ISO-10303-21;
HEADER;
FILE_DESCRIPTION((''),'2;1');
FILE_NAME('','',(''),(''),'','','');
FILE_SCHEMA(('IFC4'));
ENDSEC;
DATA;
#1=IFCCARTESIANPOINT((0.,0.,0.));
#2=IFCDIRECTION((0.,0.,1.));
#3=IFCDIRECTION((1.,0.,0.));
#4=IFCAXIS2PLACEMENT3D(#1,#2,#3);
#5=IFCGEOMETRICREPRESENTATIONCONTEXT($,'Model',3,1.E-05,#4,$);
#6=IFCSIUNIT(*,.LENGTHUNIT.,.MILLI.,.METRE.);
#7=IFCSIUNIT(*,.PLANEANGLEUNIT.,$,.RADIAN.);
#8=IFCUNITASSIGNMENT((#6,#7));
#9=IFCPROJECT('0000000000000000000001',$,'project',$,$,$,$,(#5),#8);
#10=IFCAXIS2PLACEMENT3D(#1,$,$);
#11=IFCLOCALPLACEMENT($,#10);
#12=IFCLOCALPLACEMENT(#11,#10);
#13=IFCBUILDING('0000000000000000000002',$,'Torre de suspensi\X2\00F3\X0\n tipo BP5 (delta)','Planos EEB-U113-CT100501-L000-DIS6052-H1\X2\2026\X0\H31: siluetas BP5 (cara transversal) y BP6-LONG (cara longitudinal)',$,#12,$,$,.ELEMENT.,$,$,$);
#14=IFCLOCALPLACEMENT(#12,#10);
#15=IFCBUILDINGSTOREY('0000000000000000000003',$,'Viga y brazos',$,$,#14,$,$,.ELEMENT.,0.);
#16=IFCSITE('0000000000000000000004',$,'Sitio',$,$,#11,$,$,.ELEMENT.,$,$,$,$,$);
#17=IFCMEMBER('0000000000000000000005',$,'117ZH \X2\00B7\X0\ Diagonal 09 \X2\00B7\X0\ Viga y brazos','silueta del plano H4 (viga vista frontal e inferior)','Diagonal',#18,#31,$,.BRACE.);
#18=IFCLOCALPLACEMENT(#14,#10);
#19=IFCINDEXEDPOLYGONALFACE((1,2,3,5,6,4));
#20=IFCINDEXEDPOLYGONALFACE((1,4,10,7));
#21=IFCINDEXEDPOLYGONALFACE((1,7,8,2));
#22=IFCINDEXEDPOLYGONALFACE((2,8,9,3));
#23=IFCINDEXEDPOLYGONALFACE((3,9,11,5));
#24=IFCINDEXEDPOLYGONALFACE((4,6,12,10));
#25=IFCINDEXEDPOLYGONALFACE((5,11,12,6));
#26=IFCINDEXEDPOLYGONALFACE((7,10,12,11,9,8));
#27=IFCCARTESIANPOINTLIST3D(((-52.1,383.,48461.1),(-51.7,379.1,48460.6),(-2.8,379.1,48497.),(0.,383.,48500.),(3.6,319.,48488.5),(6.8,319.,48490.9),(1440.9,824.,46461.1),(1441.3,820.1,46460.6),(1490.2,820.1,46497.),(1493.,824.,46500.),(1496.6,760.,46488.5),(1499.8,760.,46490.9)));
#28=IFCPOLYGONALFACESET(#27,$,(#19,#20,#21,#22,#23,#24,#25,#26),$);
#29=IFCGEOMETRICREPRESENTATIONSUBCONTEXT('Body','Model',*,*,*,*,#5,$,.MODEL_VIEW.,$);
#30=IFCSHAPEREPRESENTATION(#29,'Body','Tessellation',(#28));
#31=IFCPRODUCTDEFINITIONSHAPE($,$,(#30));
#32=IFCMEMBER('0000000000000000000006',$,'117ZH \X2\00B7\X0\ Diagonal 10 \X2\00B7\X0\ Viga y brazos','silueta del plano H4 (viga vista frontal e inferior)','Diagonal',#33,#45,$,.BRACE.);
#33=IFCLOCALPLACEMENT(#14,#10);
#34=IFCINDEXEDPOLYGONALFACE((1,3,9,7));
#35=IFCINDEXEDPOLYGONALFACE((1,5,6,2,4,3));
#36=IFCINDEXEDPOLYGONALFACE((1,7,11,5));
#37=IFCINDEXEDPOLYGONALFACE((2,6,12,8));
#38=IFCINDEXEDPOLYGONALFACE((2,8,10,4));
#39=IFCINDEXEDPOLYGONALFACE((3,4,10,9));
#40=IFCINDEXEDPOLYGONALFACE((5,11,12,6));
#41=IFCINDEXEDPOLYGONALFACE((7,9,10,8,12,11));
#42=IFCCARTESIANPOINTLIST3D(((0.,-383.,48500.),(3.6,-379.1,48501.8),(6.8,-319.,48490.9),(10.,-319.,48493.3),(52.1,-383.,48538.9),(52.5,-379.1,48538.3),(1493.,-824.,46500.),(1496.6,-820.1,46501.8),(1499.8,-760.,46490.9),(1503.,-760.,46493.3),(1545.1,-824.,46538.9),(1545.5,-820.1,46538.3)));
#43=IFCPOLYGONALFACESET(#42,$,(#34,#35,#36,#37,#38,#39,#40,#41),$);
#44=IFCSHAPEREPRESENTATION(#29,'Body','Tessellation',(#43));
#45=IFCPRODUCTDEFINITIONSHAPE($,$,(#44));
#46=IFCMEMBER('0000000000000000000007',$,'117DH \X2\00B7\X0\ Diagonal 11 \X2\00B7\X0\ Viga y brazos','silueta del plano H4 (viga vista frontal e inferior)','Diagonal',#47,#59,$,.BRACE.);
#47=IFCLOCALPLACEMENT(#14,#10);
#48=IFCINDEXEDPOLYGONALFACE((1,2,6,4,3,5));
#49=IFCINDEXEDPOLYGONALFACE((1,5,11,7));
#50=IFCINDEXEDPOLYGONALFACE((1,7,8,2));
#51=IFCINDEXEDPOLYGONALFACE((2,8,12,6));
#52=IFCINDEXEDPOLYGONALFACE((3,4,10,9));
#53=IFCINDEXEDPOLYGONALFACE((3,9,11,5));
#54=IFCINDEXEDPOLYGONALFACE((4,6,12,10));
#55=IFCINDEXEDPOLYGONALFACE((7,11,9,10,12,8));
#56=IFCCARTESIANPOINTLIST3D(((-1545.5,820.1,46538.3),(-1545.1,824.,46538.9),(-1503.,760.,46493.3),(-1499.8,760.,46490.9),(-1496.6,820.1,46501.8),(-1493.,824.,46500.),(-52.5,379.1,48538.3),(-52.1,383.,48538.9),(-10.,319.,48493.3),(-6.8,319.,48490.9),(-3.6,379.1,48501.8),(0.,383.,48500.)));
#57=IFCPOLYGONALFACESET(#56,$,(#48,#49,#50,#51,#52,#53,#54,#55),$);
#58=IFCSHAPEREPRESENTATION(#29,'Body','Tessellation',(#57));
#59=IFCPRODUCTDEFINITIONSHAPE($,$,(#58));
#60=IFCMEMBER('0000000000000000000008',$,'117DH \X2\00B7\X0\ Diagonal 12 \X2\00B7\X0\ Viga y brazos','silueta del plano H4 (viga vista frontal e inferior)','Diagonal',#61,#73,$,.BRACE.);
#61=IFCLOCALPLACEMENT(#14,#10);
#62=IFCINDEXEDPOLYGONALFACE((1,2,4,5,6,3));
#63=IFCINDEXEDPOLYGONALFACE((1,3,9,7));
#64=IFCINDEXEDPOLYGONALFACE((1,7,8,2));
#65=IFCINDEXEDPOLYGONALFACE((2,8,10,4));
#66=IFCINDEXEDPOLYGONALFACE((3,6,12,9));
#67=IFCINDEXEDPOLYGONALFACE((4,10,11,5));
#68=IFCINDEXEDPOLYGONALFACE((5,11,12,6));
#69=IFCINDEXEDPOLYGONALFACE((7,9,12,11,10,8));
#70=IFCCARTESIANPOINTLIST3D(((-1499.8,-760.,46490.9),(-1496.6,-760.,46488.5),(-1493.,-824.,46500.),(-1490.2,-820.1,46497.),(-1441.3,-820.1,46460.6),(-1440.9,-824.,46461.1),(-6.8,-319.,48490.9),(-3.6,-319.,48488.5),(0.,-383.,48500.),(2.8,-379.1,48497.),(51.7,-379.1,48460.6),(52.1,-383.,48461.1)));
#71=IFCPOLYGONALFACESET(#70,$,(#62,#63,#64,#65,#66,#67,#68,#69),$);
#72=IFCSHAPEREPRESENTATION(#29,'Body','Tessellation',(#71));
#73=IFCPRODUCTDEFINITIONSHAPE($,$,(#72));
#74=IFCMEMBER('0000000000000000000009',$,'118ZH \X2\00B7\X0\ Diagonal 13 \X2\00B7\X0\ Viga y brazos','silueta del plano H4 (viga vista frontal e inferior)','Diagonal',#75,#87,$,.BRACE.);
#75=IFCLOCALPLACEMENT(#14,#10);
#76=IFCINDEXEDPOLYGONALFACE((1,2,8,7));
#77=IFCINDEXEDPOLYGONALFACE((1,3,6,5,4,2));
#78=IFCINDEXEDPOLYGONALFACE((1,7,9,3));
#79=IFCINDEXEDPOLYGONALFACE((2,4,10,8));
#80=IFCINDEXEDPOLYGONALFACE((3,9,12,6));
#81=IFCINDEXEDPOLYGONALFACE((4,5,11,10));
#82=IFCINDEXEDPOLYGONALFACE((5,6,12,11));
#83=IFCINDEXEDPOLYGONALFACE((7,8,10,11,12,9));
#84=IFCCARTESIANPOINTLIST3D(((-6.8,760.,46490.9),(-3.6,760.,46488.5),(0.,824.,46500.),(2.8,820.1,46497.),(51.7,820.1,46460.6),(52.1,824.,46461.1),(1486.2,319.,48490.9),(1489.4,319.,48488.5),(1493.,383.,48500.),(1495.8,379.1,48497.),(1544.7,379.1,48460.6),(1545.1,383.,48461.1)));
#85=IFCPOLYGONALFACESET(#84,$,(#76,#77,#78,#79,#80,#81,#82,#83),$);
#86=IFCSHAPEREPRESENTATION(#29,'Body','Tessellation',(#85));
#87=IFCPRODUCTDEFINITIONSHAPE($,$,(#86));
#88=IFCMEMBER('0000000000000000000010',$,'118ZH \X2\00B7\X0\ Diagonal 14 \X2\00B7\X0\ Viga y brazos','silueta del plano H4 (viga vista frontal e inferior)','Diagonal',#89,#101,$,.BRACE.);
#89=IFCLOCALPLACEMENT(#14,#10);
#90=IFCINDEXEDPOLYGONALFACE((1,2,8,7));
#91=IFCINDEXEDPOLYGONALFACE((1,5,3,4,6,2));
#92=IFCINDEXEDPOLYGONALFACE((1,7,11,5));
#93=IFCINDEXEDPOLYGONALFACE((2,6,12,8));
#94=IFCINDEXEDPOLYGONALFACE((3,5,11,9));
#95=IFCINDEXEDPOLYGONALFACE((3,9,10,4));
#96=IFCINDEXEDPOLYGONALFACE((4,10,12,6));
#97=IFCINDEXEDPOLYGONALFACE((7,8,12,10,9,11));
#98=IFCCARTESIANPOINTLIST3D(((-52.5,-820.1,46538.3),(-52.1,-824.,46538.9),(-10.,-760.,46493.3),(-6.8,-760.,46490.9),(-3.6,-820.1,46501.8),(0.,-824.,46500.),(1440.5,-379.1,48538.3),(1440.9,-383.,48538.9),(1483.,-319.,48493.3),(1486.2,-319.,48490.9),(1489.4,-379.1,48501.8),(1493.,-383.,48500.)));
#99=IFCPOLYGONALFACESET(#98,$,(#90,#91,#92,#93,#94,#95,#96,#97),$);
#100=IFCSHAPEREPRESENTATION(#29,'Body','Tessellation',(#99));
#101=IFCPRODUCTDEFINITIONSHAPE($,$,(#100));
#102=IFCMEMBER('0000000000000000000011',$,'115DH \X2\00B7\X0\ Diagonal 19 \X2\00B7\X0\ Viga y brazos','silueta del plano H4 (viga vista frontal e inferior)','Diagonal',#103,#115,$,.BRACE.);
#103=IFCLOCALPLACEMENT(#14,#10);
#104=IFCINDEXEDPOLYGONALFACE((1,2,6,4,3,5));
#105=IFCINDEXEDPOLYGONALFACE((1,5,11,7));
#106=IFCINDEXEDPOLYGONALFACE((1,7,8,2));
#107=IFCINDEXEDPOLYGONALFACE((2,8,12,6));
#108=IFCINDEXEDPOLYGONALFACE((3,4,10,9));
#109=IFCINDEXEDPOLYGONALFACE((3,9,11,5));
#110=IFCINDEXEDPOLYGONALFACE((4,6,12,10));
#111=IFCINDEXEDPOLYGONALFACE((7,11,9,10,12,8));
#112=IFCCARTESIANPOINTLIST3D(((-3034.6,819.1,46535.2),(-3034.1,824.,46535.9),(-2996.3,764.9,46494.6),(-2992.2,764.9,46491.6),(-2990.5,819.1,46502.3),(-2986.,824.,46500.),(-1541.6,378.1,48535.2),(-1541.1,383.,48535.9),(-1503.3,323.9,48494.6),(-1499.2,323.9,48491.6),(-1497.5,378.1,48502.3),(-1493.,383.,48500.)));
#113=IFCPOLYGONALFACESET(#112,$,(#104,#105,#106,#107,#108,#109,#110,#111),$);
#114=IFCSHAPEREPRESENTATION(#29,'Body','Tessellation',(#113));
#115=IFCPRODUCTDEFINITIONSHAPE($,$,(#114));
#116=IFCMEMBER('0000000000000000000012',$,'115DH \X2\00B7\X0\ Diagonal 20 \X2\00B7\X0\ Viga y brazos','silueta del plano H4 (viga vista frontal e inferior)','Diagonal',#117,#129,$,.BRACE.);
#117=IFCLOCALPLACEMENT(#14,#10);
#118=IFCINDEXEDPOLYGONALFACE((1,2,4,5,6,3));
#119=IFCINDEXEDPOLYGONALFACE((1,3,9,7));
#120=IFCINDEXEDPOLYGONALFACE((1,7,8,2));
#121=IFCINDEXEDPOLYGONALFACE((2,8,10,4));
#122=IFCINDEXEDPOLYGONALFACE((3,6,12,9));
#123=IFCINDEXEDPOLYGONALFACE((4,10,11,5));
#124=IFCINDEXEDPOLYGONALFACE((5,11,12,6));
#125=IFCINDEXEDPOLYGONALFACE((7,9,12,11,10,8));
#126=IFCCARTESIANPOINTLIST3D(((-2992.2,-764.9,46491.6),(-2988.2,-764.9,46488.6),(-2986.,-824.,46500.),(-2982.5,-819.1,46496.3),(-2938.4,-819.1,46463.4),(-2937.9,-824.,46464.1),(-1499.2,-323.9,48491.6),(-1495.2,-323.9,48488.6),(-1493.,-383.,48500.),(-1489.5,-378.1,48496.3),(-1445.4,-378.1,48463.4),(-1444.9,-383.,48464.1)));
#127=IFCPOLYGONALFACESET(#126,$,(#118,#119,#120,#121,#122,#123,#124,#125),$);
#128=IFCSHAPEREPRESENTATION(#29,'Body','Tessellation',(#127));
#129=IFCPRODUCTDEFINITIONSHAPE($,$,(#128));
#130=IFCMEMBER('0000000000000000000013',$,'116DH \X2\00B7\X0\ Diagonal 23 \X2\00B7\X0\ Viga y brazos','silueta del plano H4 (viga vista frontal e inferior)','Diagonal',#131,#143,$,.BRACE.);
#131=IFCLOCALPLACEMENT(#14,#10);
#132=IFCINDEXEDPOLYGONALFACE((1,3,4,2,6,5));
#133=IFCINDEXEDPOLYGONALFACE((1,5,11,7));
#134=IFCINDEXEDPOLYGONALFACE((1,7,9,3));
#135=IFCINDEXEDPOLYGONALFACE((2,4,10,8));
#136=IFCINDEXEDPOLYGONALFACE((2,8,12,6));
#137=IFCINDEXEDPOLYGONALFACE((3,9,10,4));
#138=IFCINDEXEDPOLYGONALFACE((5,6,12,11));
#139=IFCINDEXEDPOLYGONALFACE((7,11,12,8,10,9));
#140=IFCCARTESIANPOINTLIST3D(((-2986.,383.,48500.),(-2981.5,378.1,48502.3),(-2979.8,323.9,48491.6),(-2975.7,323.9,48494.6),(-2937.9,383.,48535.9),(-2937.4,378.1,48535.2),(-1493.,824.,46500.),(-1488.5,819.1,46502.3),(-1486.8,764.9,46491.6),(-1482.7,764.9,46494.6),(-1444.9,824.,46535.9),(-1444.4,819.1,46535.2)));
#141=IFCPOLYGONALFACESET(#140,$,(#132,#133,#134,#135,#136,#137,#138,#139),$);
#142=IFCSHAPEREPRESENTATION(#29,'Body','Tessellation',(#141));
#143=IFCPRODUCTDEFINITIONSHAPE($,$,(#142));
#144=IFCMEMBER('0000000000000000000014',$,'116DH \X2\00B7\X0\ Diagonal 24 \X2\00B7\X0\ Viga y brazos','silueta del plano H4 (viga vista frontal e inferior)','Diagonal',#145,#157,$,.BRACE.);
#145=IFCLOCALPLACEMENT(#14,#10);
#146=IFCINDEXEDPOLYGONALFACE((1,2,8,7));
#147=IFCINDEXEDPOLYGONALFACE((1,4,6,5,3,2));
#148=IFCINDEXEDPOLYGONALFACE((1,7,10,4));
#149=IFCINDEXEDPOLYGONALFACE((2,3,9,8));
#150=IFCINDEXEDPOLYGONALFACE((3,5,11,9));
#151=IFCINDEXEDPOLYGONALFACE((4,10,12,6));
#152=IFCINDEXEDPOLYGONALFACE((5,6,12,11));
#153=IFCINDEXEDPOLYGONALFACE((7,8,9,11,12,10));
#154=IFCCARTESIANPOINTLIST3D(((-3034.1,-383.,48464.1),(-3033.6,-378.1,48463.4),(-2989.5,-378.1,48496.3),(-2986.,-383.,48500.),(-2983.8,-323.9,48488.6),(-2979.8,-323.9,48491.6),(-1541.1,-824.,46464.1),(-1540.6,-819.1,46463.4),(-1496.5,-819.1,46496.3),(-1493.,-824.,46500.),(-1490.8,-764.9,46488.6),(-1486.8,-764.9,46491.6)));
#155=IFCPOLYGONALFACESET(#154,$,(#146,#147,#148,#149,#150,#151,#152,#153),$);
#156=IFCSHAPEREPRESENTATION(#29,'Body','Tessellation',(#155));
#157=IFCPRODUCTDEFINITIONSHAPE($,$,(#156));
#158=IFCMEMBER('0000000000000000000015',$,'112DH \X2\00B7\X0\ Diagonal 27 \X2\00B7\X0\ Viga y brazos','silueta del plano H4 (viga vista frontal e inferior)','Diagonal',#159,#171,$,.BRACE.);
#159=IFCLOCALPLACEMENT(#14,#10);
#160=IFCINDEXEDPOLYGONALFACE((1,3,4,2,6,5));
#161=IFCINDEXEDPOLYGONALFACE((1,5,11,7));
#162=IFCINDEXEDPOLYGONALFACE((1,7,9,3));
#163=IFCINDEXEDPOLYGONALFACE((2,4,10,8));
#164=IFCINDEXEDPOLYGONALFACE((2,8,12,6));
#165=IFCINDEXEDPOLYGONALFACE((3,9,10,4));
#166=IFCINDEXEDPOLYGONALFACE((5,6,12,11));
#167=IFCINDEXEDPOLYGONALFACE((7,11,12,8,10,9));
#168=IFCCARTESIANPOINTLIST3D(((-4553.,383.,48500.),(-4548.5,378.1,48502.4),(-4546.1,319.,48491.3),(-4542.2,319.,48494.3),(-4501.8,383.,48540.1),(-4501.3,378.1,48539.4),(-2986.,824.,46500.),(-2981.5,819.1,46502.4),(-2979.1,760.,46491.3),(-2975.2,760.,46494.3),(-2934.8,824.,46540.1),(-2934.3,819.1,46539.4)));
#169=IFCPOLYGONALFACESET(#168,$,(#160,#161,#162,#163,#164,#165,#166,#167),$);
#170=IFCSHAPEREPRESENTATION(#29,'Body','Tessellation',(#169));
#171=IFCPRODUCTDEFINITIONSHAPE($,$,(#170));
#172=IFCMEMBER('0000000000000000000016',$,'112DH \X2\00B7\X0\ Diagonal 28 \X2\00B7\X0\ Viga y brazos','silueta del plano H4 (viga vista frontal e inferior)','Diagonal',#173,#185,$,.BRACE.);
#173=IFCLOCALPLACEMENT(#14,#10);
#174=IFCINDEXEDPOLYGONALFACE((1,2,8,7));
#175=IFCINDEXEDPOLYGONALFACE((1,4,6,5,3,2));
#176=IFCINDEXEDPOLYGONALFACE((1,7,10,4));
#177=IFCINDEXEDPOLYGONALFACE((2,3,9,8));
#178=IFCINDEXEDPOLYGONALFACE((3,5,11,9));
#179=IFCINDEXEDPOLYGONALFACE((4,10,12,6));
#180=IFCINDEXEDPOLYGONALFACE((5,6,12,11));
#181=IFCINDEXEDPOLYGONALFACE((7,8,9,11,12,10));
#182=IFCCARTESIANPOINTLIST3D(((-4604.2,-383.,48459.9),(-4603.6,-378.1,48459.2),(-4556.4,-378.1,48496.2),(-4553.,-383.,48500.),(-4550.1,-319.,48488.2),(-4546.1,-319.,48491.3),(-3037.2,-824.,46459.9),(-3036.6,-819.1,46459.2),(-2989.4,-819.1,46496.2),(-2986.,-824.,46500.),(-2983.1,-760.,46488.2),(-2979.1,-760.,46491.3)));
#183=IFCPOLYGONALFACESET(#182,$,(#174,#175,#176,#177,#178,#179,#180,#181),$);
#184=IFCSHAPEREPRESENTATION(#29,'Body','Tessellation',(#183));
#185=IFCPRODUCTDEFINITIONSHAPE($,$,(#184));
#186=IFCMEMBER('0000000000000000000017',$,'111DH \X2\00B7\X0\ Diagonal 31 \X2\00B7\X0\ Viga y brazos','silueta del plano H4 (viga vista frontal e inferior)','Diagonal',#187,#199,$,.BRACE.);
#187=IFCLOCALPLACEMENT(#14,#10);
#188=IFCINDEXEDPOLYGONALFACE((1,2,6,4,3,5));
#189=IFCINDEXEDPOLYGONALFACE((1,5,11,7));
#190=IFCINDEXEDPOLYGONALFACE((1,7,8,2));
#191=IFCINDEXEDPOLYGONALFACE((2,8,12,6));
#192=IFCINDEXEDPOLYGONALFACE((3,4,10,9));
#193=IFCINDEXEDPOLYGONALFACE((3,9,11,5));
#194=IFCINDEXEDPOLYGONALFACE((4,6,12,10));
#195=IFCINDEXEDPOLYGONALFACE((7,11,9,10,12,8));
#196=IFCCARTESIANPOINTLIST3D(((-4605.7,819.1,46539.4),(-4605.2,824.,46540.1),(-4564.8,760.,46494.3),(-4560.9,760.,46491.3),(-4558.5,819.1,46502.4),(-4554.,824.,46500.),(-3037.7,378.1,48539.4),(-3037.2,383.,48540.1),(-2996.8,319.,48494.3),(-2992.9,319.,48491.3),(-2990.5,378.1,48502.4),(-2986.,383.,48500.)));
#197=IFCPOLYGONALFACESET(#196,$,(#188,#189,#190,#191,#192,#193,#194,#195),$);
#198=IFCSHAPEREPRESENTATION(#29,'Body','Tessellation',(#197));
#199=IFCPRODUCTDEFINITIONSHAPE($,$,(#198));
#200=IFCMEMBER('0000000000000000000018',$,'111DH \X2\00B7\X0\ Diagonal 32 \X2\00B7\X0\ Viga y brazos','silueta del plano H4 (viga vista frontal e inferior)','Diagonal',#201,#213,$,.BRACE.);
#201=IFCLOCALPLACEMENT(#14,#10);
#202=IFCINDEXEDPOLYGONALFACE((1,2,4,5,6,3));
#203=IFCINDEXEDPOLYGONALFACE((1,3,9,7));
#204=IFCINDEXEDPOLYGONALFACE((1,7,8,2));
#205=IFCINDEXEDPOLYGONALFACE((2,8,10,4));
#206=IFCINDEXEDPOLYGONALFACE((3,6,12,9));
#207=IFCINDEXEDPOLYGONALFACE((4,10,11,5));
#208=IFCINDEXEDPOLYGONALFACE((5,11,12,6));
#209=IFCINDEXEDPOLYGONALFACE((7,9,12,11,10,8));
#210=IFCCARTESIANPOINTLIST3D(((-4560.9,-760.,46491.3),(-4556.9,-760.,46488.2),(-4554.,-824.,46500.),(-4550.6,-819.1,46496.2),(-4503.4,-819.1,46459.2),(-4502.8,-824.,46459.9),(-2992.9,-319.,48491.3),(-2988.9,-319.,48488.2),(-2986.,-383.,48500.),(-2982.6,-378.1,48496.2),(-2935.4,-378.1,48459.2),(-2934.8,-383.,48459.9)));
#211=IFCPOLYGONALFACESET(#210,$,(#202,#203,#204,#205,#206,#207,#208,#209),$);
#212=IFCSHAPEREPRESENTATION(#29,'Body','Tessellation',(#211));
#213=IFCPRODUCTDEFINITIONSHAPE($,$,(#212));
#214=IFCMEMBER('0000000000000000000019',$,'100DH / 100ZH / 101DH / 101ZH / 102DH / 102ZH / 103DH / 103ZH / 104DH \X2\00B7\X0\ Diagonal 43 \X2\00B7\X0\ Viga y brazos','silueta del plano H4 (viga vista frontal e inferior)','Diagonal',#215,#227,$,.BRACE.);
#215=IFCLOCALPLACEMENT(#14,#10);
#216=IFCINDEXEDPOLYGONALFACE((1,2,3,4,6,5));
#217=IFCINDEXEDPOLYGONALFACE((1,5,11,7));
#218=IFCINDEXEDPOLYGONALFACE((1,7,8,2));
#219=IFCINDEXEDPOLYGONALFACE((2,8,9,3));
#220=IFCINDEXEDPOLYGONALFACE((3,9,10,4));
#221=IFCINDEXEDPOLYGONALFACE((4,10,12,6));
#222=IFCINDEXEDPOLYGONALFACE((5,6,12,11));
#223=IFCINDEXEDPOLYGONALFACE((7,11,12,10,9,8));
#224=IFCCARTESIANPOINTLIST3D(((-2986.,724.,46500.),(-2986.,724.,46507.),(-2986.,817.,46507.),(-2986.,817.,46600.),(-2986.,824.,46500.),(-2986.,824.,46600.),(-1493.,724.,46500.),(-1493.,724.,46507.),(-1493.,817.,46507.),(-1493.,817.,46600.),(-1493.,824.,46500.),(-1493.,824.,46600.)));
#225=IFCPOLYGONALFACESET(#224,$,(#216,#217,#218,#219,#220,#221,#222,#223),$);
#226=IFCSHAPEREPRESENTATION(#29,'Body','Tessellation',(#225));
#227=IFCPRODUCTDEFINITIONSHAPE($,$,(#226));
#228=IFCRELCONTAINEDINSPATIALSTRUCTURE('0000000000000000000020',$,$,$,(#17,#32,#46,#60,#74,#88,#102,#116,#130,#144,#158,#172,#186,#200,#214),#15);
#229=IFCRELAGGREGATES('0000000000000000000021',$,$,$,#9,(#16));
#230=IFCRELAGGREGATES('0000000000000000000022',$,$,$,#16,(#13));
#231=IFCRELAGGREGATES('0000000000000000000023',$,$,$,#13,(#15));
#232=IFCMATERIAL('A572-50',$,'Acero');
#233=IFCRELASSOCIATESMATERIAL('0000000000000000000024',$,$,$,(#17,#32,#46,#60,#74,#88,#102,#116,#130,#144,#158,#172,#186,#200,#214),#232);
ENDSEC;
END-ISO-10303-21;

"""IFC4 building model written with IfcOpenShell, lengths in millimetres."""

from ifc_helpers import new_model, si_unit, frame, frame_2d, origin, origin_with_axes, place, context, subcontext, project, spatial, l_section, extrude, material, element, save


model = new_model("IFC4")

# Units and contexts
model_context = context("Model", 3, precision=1e-05, world=origin_with_axes())
body_context = subcontext(model_context, "Body", "Model", "MODEL_VIEW")
ifc_project = project(units=[si_unit("LENGTHUNIT", "METRE", prefix="MILLI"), si_unit("PLANEANGLEUNIT", "RADIAN")], contexts=[model_context])

# Site, building, storey
site_placement = place(None, origin())
site = spatial("IfcSite", under=ifc_project, at=site_placement, Name="Sitio", CompositionType="ELEMENT")
building_placement = place(site_placement, origin())
building = spatial("IfcBuilding", under=site, at=building_placement, Name="Torre de suspensión tipo BP5 (delta)", Description="Planos EEB-U113-CT100501-L000-DIS6052-H1…H31: siluetas BP5 (cara transversal) y BP6-LONG (cara longitudinal)", CompositionType="ELEMENT")
storey_placement = place(building_placement, origin())
storey = spatial("IfcBuildingStorey", under=building, at=storey_placement, Name="Viga y brazos", CompositionType="ELEMENT", Elevation=0.0)

# Members
ifc_material_1 = material(Name="A572-50", Category="Acero")
for number, where, z_axis, x_axis, name in (
    (1, (0.0, 383.0, 48500.0), (0.589078, 0.174001, -0.78912), (0.104088, -0.984745, -0.139435), "117ZH · Diagonal 09 · Viga y brazos"),
    (2, (0.0, -383.0, 48500.0), (0.589078, -0.174001, -0.78912), (0.104088, 0.984745, -0.139435), "117ZH · Diagonal 10 · Viga y brazos"),
    (3, (0.0, 383.0, 48500.0), (-0.589078, 0.174001, -0.78912), (-0.104088, -0.984745, -0.139435), "117DH · Diagonal 11 · Viga y brazos"),
    (4, (0.0, -383.0, 48500.0), (-0.589078, -0.174001, -0.78912), (-0.104088, 0.984745, -0.139435), "117DH · Diagonal 12 · Viga y brazos"),
    (5, (0.0, 824.0, 46500.0), (0.589078, -0.174001, 0.78912), (-0.104088, -0.984745, -0.139435), "118ZH · Diagonal 13 · Viga y brazos"),
    (6, (0.0, -824.0, 46500.0), (0.589078, 0.174001, 0.78912), (-0.104088, 0.984745, -0.139435), "118ZH · Diagonal 14 · Viga y brazos"),
):
    element("IfcMember", number, at=place(storey_placement, frame(where, z_axis=z_axis, x_axis=x_axis)), inside=storey, material=ifc_material_1, Name=name, Description="silueta del plano H4 (viga vista frontal e inferior)", ObjectType="Diagonal", PredefinedType="BRACE", context=body_context, shape_type="SweptSolid", body=[
        extrude(l_section(Depth=65.0, Width=65.0, Thickness=4.0, at=frame_2d((32.5, 32.5))), None, (0.0, 0.0, 1.0), 2534.5),
    ])
for number, where, z_axis, x_axis, name in (
    (7, (-1493.0, 383.0, 48500.0), (-0.589078, 0.174001, -0.78912), (-0.104088, -0.984745, -0.139435), "115DH · Diagonal 19 · Viga y brazos"),
    (8, (-1493.0, -383.0, 48500.0), (-0.589078, -0.174001, -0.78912), (-0.104088, 0.984745, -0.139435), "115DH · Diagonal 20 · Viga y brazos"),
    (9, (-1493.0, 824.0, 46500.0), (-0.589078, -0.174001, 0.78912), (0.104088, -0.984745, -0.139435), "116DH · Diagonal 23 · Viga y brazos"),
    (10, (-1493.0, -824.0, 46500.0), (-0.589078, 0.174001, 0.78912), (0.104088, 0.984745, -0.139435), "116DH · Diagonal 24 · Viga y brazos"),
):
    element("IfcMember", number, at=place(storey_placement, frame(where, z_axis=z_axis, x_axis=x_axis)), inside=storey, material=ifc_material_1, Name=name, Description="silueta del plano H4 (viga vista frontal e inferior)", ObjectType="Diagonal", PredefinedType="BRACE", context=body_context, shape_type="SweptSolid", body=[
        extrude(l_section(Depth=60.0, Width=60.0, Thickness=5.0, at=frame_2d((30.0, 30.0))), None, (0.0, 0.0, 1.0), 2534.5),
    ])
for number, where, z_axis, x_axis, name in (
    (11, (-2986.0, 824.0, 46500.0), (-0.607658, -0.171013, 0.775568), (0.105471, -0.985269, -0.134615), "112DH · Diagonal 27 · Viga y brazos"),
    (12, (-2986.0, -824.0, 46500.0), (-0.607658, 0.171013, 0.775568), (0.105471, 0.985269, -0.134615), "112DH · Diagonal 28 · Viga y brazos"),
):
    element("IfcMember", number, at=place(storey_placement, frame(where, z_axis=z_axis, x_axis=x_axis)), inside=storey, material=ifc_material_1, Name=name, Description="silueta del plano H4 (viga vista frontal e inferior)", ObjectType="Diagonal", PredefinedType="BRACE", context=body_context, shape_type="SweptSolid", body=[
        extrude(l_section(Depth=65.0, Width=65.0, Thickness=5.0, at=frame_2d((32.5, 32.5))), None, (0.0, 0.0, 1.0), 2578.8),
    ])
for number, where, z_axis, x_axis, name in (
    (13, (-2986.0, 383.0, 48500.0), (-0.607902, 0.170973, -0.775386), (-0.105488, -0.985276, -0.134551), "111DH · Diagonal 31 · Viga y brazos"),
    (14, (-2986.0, -383.0, 48500.0), (-0.607902, -0.170973, -0.775386), (-0.105488, 0.985276, -0.134551), "111DH · Diagonal 32 · Viga y brazos"),
):
    element("IfcMember", number, at=place(storey_placement, frame(where, z_axis=z_axis, x_axis=x_axis)), inside=storey, material=ifc_material_1, Name=name, Description="silueta del plano H4 (viga vista frontal e inferior)", ObjectType="Diagonal", PredefinedType="BRACE", context=body_context, shape_type="SweptSolid", body=[
        extrude(l_section(Depth=65.0, Width=65.0, Thickness=5.0, at=frame_2d((32.5, 32.5))), None, (0.0, 0.0, 1.0), 2579.4),
    ])
for number, where, z_axis, x_axis, name in (
    (15, (-1493.0, 824.0, 46500.0), (-1.0, 0.0, 0.0), (0.0, -1.0, 0.0), "100DH / 100ZH / 101DH / 101ZH / 102DH / 102ZH / 103DH / 103ZH / 104DH · Diagonal 43 · Viga y brazos"),
):
    element("IfcMember", number, at=place(storey_placement, frame(where, z_axis=z_axis, x_axis=x_axis)), inside=storey, material=ifc_material_1, Name=name, Description="silueta del plano H4 (viga vista frontal e inferior)", ObjectType="Diagonal", PredefinedType="BRACE", context=body_context, shape_type="SweptSolid", body=[
        extrude(l_section(Depth=100.0, Width=100.0, Thickness=7.0, at=frame_2d((50.0, 50.0))), None, (0.0, 0.0, 1.0), 1493.0),
    ])

save(model, "model.ifc")
